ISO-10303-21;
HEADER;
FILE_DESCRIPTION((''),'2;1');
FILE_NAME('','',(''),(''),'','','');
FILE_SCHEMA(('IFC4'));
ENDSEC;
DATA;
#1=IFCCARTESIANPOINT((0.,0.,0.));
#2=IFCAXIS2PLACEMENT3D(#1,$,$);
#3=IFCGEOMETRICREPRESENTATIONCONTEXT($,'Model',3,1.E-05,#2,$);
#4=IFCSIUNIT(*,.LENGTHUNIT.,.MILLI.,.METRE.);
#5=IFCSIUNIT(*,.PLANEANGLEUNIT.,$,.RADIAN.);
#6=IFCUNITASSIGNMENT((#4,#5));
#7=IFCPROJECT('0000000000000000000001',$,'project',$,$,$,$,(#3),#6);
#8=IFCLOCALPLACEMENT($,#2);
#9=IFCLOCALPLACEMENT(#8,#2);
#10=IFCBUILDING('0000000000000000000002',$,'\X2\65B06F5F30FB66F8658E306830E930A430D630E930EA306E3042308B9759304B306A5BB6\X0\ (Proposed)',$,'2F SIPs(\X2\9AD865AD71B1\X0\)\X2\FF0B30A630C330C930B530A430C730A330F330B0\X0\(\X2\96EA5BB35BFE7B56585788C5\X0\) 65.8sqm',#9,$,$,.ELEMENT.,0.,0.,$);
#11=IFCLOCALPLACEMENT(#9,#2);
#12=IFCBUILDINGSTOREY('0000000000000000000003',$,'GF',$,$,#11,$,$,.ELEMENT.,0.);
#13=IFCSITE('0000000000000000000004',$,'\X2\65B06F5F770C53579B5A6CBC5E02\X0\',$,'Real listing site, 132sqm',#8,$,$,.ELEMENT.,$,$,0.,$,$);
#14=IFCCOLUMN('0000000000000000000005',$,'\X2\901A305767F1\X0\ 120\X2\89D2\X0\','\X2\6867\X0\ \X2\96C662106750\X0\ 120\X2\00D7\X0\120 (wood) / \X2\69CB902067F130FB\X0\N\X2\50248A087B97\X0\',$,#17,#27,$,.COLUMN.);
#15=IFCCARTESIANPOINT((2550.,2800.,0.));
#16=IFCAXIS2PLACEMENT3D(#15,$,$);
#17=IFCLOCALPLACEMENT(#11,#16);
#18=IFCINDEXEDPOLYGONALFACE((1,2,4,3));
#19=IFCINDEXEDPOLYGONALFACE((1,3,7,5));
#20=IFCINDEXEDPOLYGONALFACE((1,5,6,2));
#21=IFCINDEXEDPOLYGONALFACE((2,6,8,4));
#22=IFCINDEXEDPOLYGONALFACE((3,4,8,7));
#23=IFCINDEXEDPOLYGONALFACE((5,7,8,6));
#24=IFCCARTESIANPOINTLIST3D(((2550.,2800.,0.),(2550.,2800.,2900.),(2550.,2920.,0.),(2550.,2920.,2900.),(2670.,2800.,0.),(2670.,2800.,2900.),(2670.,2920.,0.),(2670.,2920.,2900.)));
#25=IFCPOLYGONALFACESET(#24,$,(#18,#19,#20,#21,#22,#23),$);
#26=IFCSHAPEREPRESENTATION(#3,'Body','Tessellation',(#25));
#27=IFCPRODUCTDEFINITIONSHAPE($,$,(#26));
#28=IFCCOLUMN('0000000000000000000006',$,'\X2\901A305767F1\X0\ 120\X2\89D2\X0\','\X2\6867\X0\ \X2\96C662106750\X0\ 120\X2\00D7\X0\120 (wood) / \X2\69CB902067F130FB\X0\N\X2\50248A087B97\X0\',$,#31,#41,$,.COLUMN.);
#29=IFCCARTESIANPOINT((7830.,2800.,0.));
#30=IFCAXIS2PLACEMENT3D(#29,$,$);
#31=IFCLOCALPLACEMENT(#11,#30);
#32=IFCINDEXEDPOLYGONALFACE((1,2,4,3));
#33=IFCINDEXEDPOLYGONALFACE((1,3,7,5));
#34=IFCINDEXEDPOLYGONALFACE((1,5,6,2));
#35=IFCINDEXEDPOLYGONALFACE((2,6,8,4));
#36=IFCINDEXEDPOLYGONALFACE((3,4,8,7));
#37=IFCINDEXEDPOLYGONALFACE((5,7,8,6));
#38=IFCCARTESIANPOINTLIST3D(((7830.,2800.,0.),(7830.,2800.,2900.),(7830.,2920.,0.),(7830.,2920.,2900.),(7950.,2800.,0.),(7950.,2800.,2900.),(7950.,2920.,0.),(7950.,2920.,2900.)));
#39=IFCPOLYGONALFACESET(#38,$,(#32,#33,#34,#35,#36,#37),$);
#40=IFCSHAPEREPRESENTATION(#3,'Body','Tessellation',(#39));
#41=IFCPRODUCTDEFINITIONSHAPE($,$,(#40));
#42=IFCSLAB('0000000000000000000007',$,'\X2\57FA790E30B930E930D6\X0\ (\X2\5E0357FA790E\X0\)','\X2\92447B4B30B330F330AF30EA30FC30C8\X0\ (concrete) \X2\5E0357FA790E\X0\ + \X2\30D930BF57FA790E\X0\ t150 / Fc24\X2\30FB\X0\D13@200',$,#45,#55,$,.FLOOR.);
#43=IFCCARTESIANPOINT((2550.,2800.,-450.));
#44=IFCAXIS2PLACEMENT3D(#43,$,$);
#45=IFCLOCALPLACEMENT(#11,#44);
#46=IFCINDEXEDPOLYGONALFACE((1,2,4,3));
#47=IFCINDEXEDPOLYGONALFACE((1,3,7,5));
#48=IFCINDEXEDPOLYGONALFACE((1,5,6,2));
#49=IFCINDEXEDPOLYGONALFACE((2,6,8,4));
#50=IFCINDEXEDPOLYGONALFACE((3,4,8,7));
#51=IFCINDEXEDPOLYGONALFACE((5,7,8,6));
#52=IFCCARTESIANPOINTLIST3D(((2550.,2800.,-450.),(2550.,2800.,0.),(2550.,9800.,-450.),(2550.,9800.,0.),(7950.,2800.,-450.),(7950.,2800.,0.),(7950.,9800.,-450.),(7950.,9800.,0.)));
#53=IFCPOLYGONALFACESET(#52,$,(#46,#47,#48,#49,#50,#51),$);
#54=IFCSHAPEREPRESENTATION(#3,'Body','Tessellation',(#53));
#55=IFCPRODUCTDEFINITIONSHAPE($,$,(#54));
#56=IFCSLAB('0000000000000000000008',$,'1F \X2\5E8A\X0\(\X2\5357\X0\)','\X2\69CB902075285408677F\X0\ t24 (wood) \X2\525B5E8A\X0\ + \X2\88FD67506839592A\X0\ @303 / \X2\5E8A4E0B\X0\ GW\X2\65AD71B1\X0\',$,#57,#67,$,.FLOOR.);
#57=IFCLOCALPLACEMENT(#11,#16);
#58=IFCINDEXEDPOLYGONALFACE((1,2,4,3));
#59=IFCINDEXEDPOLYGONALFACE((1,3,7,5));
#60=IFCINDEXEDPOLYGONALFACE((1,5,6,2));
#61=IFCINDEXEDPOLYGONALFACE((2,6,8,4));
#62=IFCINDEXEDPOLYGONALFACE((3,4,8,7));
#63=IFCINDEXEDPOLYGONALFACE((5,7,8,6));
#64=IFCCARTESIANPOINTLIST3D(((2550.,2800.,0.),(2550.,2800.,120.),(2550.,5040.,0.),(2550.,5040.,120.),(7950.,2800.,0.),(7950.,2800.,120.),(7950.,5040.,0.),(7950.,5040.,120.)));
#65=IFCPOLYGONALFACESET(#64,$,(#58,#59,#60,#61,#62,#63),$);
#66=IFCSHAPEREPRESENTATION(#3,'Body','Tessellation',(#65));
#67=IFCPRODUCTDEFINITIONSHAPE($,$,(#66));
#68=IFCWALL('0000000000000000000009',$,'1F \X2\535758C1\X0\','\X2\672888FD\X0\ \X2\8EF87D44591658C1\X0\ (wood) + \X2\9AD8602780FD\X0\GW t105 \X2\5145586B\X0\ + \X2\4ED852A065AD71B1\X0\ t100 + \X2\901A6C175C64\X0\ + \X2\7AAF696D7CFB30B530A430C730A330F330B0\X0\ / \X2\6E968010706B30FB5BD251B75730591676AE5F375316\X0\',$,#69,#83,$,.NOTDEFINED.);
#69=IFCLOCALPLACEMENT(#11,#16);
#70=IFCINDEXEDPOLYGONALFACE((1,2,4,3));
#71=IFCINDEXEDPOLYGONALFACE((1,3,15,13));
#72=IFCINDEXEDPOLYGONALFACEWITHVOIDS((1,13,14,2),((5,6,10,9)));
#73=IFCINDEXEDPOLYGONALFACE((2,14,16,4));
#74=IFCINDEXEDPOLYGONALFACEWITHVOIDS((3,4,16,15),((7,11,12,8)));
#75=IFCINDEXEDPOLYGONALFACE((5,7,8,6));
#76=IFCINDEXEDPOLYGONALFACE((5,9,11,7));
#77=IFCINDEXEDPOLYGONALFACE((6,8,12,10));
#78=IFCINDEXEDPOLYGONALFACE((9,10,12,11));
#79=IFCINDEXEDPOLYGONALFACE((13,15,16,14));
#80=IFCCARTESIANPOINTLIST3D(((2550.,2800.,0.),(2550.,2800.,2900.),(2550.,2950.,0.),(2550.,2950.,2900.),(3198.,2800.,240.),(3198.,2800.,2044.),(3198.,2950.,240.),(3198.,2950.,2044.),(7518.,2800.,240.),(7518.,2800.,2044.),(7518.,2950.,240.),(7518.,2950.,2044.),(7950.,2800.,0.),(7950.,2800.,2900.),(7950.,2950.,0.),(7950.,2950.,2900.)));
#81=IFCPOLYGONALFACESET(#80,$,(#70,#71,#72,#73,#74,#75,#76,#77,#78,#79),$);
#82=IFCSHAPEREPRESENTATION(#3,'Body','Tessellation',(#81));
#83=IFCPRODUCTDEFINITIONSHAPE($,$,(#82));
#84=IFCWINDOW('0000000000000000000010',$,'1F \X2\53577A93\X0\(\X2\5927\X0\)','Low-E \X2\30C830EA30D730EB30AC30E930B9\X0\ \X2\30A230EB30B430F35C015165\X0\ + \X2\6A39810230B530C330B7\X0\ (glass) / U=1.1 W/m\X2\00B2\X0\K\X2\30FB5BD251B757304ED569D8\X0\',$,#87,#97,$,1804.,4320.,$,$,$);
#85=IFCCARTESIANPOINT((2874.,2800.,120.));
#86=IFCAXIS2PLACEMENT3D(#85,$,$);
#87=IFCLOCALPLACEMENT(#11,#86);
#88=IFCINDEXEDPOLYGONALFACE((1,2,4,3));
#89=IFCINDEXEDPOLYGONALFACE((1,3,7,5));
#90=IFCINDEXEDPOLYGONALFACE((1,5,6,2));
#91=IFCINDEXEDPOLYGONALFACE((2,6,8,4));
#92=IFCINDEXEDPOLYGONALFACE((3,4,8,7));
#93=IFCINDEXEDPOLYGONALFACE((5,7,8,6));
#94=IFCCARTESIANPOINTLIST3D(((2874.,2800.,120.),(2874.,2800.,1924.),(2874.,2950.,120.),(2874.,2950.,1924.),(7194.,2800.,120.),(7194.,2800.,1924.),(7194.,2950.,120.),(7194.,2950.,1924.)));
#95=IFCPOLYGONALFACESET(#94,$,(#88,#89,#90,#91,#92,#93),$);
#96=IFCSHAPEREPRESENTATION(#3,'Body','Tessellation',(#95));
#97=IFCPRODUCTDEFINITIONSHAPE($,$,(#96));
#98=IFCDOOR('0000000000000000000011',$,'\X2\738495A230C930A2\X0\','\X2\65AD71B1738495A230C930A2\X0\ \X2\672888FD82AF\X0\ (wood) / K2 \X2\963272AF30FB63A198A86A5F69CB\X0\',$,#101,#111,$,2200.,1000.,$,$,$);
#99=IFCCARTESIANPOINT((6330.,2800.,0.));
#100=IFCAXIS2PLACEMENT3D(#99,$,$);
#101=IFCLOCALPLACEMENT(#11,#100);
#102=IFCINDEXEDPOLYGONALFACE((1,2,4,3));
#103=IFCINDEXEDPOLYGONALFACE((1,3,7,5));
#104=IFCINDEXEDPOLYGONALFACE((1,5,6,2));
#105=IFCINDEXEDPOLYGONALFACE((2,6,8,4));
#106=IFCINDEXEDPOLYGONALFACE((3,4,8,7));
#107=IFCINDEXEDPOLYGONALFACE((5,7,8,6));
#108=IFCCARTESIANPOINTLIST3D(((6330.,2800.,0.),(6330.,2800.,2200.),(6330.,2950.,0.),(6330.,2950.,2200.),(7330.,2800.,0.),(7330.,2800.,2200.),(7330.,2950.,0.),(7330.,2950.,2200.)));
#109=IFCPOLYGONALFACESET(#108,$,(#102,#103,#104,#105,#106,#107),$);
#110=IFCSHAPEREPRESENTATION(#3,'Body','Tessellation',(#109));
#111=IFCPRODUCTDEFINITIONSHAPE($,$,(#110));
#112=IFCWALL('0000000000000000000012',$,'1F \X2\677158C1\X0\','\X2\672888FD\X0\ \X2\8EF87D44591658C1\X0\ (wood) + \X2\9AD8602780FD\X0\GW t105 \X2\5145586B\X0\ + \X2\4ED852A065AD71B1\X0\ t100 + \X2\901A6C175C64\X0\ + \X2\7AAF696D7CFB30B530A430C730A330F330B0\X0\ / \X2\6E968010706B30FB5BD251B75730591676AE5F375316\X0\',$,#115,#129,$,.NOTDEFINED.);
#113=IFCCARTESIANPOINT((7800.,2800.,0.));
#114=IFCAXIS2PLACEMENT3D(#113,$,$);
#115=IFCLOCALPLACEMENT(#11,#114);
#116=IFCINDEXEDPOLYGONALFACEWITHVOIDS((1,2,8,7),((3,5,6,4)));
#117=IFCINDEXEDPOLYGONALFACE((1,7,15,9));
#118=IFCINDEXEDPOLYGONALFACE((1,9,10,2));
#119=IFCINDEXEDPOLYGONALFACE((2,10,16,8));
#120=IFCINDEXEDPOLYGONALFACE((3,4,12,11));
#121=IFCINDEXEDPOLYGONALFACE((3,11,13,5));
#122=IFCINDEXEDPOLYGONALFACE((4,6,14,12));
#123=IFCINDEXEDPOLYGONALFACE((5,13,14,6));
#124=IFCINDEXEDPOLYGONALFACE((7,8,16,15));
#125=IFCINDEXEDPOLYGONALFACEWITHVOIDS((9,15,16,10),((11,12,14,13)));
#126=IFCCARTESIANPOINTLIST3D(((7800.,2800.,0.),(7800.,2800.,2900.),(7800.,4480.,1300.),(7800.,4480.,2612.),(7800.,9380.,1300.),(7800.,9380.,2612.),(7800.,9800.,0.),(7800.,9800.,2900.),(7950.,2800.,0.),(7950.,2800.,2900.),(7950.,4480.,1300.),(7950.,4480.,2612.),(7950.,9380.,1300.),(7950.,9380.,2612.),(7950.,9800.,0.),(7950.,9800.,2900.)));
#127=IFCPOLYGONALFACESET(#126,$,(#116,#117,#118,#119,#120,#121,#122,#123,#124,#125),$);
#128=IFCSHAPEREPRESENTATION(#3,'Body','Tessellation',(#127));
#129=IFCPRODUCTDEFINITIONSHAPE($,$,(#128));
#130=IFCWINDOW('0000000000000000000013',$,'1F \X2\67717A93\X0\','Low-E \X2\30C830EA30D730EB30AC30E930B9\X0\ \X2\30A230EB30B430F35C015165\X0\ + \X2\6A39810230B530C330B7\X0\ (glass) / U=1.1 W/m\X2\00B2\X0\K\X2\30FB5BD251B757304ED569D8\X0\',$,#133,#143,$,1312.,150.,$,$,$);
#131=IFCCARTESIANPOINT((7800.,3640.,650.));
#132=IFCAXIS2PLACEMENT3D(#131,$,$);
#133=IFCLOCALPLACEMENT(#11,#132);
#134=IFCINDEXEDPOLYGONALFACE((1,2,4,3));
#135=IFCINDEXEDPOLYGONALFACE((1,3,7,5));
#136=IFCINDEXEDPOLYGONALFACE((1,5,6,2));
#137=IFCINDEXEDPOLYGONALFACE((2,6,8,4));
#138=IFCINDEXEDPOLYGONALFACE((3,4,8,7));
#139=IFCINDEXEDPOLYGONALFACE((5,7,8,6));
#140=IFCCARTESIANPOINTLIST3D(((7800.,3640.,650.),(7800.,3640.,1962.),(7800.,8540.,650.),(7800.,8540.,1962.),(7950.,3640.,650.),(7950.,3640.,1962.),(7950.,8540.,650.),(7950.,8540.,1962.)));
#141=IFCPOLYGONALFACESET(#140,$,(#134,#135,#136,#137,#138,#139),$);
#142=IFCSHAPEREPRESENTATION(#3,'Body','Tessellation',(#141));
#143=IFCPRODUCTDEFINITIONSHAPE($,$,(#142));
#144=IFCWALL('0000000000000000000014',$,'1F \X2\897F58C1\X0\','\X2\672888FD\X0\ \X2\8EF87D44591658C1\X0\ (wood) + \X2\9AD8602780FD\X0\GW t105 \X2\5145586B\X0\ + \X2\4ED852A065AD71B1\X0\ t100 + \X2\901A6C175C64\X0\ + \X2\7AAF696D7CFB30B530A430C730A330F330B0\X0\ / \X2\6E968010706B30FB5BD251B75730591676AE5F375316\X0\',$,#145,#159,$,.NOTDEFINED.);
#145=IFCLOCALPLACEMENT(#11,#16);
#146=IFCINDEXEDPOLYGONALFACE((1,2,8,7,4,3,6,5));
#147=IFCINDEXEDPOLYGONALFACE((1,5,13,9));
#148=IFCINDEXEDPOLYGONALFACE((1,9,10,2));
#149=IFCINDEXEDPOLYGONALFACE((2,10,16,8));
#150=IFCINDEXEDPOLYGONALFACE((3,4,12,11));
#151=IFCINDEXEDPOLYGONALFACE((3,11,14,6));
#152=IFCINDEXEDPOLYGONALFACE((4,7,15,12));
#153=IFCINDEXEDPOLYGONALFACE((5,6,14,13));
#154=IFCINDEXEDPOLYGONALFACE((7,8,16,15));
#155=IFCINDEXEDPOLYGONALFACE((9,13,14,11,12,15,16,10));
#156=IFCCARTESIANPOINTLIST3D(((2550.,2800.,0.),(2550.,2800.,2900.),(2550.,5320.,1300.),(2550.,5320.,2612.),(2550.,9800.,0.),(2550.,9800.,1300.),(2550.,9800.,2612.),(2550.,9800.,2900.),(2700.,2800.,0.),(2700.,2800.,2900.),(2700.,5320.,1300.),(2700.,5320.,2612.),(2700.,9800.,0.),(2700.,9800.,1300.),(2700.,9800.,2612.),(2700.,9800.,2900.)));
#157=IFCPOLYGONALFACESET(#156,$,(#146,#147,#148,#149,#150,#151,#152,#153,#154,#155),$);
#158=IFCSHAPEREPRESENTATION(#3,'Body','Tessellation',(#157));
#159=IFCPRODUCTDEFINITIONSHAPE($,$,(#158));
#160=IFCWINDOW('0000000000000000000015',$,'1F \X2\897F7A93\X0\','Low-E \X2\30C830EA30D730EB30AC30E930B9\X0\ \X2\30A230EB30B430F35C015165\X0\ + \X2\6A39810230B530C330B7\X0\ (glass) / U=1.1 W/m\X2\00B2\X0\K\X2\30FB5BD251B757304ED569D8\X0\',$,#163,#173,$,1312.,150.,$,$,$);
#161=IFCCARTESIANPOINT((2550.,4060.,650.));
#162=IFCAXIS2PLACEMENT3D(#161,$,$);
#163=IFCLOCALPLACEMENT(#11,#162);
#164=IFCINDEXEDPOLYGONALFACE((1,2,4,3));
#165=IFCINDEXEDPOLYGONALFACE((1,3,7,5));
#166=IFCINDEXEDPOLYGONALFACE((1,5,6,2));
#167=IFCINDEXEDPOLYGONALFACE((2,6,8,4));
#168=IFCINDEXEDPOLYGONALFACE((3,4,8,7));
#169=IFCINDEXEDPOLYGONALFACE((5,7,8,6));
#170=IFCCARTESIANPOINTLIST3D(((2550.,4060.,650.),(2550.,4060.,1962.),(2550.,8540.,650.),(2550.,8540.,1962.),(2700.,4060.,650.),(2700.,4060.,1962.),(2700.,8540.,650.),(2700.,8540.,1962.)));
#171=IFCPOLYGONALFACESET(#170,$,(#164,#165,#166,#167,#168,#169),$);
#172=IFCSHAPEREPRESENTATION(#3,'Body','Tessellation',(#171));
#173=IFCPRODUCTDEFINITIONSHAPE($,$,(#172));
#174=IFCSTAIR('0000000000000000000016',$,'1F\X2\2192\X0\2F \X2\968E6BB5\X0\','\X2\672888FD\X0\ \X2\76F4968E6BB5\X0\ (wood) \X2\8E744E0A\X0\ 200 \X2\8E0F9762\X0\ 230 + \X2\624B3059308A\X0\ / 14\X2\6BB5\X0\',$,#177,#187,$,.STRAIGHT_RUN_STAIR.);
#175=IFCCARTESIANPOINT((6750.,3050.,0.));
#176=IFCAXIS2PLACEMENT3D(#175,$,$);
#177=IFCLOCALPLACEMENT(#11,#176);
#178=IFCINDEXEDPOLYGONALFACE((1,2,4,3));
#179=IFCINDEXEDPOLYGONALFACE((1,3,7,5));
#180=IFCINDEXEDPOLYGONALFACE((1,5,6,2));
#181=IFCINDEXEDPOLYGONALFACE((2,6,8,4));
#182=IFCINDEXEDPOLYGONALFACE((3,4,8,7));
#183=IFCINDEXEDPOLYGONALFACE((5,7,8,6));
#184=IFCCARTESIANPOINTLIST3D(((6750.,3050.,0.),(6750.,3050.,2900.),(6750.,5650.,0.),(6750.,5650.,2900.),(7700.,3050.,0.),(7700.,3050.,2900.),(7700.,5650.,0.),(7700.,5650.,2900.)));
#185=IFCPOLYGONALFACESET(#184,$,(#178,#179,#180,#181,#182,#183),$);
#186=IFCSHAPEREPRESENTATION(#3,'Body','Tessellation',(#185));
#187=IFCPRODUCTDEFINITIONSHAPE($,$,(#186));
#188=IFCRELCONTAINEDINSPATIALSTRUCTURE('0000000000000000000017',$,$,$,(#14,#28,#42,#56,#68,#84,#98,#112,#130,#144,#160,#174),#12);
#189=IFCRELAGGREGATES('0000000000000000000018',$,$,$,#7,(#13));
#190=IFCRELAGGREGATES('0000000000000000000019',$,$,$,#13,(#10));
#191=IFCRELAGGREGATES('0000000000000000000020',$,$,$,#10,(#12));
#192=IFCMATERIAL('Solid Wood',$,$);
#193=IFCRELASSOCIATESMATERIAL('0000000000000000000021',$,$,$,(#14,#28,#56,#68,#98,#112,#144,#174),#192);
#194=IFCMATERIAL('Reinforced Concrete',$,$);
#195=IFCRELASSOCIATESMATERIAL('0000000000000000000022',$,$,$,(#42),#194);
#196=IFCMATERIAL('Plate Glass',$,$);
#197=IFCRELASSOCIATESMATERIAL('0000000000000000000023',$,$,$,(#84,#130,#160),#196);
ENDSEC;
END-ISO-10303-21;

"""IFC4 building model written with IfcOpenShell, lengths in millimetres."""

from ifc_helpers import new_model, si_unit, frame, frame_2d, origin, place, context, project, spatial, rectangle, extrude, material, element, fill, save


model = new_model("IFC4")

# Units and contexts
model_context = context("Model", 3, precision=1e-05, world=origin())
ifc_project = project(units=[si_unit("LENGTHUNIT", "METRE", prefix="MILLI"), si_unit("PLANEANGLEUNIT", "RADIAN")], contexts=[model_context])

# Site, building, storey
site_placement = place(None, origin())
site = spatial("IfcSite", under=ifc_project, at=site_placement, Name="新潟県南魚沼市", ObjectType="Real listing site, 132sqm", CompositionType="ELEMENT", RefElevation=0.0)
building_placement = place(site_placement, origin())
building = spatial("IfcBuilding", under=site, at=building_placement, Name="新潟・書斎とライブラリのある静かな家 (Proposed)", ObjectType="2F SIPs(高断熱)＋ウッドサイディング(雪害対策塗装) 65.8sqm", CompositionType="ELEMENT", ElevationOfRefHeight=0.0, ElevationOfTerrain=0.0)
storey_placement = place(building_placement, origin())
storey = spatial("IfcBuildingStorey", under=building, at=storey_placement, Name="GF", CompositionType="ELEMENT", Elevation=0.0)

# Columns
ifc_material_1 = material(Name="Solid Wood")
column_1_placement = place(storey_placement, frame((2550.0, 2800.0, 0.0)))
element("IfcColumn", 1, at=column_1_placement, inside=storey, material=ifc_material_1, Name="通し柱 120角", Description="桧 集成材 120×120 (wood) / 構造柱・N値計算", PredefinedType="COLUMN", context=model_context, shape_type="SweptSolid", body=[
    extrude(rectangle(XDim=120.0, YDim=120.0, at=frame_2d((60.0, 60.0))), frame((2550.0, 2800.0, 0.0)), (0.0, 0.0, 1.0), 2900.0),
])
column_2_placement = place(storey_placement, frame((7830.0, 2800.0, 0.0)))
element("IfcColumn", 2, at=column_2_placement, inside=storey, material=ifc_material_1, Name="通し柱 120角", Description="桧 集成材 120×120 (wood) / 構造柱・N値計算", PredefinedType="COLUMN", context=model_context, shape_type="SweptSolid", body=[
    extrude(rectangle(XDim=120.0, YDim=120.0, at=frame_2d((60.0, 60.0))), frame((7830.0, 2800.0, 0.0)), (0.0, 0.0, 1.0), 2900.0),
])

# Slabs
ifc_material_2 = material(Name="Reinforced Concrete")
slab_1_placement = place(storey_placement, frame((2550.0, 2800.0, -450.0)))
element("IfcSlab", 3, at=slab_1_placement, inside=storey, material=ifc_material_2, Name="基礎スラブ (布基礎)", Description="鉄筋コンクリート (concrete) 布基礎 + ベタ基礎 t150 / Fc24・D13@200", PredefinedType="FLOOR", context=model_context, shape_type="SweptSolid", body=[
    extrude(rectangle(XDim=5400.0, YDim=7000.0, at=frame_2d((2700.0, 3500.0))), frame((2550.0, 2800.0, -450.0)), (0.0, 0.0, 1.0), 450.0),
])
slab_2_placement = place(storey_placement, frame((2550.0, 2800.0, 0.0)))
element("IfcSlab", 4, at=slab_2_placement, inside=storey, material=ifc_material_1, Name="1F 床(南)", Description="構造用合板 t24 (wood) 剛床 + 製材根太 @303 / 床下 GW断熱", PredefinedType="FLOOR", context=model_context, shape_type="SweptSolid", body=[
    extrude(rectangle(XDim=5400.0, YDim=2240.0, at=frame_2d((2700.0, 1120.0))), frame((2550.0, 2800.0, 0.0)), (0.0, 0.0, 1.0), 120.0),
])

# Wall, openings, window, door
wall_1_placement = place(storey_placement, frame((2550.0, 2800.0, 0.0)))
wall_1 = element("IfcWall", 5, at=wall_1_placement, inside=storey, material=ifc_material_1, Name="1F 南壁", Description="木製 軸組外壁 (wood) + 高性能GW t105 充填 + 付加断熱 t100 + 通気層 + 窯業系サイディング / 準耐火・寒冷地外皮強化", PredefinedType="NOTDEFINED", context=model_context, shape_type="SweptSolid", body=[
    extrude(rectangle(XDim=5400.0, YDim=150.0, at=frame_2d((2700.0, 75.0))), frame((2550.0, 2800.0, 0.0)), (0.0, 0.0, 1.0), 2900.0),
])
opening_1_placement = place(storey_placement, frame((2874.0, 2800.0, 120.0)))
opening_1 = element("IfcOpeningElement", 6, at=opening_1_placement, cuts=wall_1, PredefinedType="NOTDEFINED", context=model_context, shape_type="SweptSolid", body=[
    extrude(rectangle(XDim=4320.0, YDim=150.0, at=frame_2d((2160.0, 75.0))), frame((2874.0, 2800.0, 120.0)), (0.0, 0.0, 1.0), 1804.0),
])
opening_2_placement = place(storey_placement, frame((6330.0, 2800.0, 0.0)))
opening_2 = element("IfcOpeningElement", 7, at=opening_2_placement, cuts=wall_1, PredefinedType="NOTDEFINED", context=model_context, shape_type="SweptSolid", body=[
    extrude(rectangle(XDim=1000.0, YDim=150.0, at=frame_2d((500.0, 75.0))), frame((6330.0, 2800.0, 0.0)), (0.0, 0.0, 1.0), 2200.0),
])
ifc_material_3 = material(Name="Plate Glass")
window_1_placement = place(storey_placement, frame((2874.0, 2800.0, 120.0)))
window_1 = element("IfcWindow", 8, at=window_1_placement, inside=storey, material=ifc_material_3, Name="1F 南窓(大)", Description="Low-E トリプルガラス アルゴン封入 + 樹脂サッシ (glass) / U=1.1 W/m²K・寒冷地仕様", OverallHeight=1804.0, OverallWidth=4320.0, context=model_context, shape_type="SweptSolid", body=[
    extrude(rectangle(XDim=4320.0, YDim=150.0, at=frame_2d((2160.0, 75.0))), frame((2874.0, 2800.0, 120.0)), (0.0, 0.0, 1.0), 1804.0),
])
fill(opening_1, window_1)
door_placement = place(storey_placement, frame((6330.0, 2800.0, 0.0)))
door = element("IfcDoor", 9, at=door_placement, inside=storey, material=ifc_material_1, Name="玄関ドア", Description="断熱玄関ドア 木製芯 (wood) / K2 防犯・採風機構", OverallHeight=2200.0, OverallWidth=1000.0, context=model_context, shape_type="SweptSolid", body=[
    extrude(rectangle(XDim=1000.0, YDim=150.0, at=frame_2d((500.0, 75.0))), frame((6330.0, 2800.0, 0.0)), (0.0, 0.0, 1.0), 2200.0),
])
fill(opening_2, door)

# Walls, openings, windows
wall_2_placement = place(storey_placement, frame((7800.0, 2800.0, 0.0)))
wall_2 = element("IfcWall", 10, at=wall_2_placement, inside=storey, material=ifc_material_1, Name="1F 東壁", Description="木製 軸組外壁 (wood) + 高性能GW t105 充填 + 付加断熱 t100 + 通気層 + 窯業系サイディング / 準耐火・寒冷地外皮強化", PredefinedType="NOTDEFINED", context=model_context, shape_type="SweptSolid", body=[
    extrude(rectangle(XDim=150.0, YDim=7000.0, at=frame_2d((75.0, 3500.0))), frame((7800.0, 2800.0, 0.0)), (0.0, 0.0, 1.0), 2900.0),
])
opening_3_placement = place(storey_placement, frame((7800.0, 3640.0, 650.0)))
opening_3 = element("IfcOpeningElement", 11, at=opening_3_placement, cuts=wall_2, PredefinedType="NOTDEFINED", context=model_context, shape_type="SweptSolid", body=[
    extrude(rectangle(XDim=150.0, YDim=4900.0, at=frame_2d((75.0, 2450.0))), frame((7800.0, 3640.0, 650.0)), (0.0, 0.0, 1.0), 1312.0),
])
window_2_placement = place(storey_placement, frame((7800.0, 3640.0, 650.0)))
window_2 = element("IfcWindow", 12, at=window_2_placement, inside=storey, material=ifc_material_3, Name="1F 東窓", Description="Low-E トリプルガラス アルゴン封入 + 樹脂サッシ (glass) / U=1.1 W/m²K・寒冷地仕様", OverallHeight=1312.0, OverallWidth=150.0, context=model_context, shape_type="SweptSolid", body=[
    extrude(rectangle(XDim=150.0, YDim=4900.0, at=frame_2d((75.0, 2450.0))), frame((7800.0, 3640.0, 650.0)), (0.0, 0.0, 1.0), 1312.0),
])
fill(opening_3, window_2)
wall_3_placement = place(storey_placement, frame((2550.0, 2800.0, 0.0)))
wall_3 = element("IfcWall", 13, at=wall_3_placement, inside=storey, material=ifc_material_1, Name="1F 西壁", Description="木製 軸組外壁 (wood) + 高性能GW t105 充填 + 付加断熱 t100 + 通気層 + 窯業系サイディング / 準耐火・寒冷地外皮強化", PredefinedType="NOTDEFINED", context=model_context, shape_type="SweptSolid", body=[
    extrude(rectangle(XDim=150.0, YDim=7000.0, at=frame_2d((75.0, 3500.0))), frame((2550.0, 2800.0, 0.0)), (0.0, 0.0, 1.0), 2900.0),
])
opening_4_placement = place(storey_placement, frame((2550.0, 4060.0, 650.0)))
opening_4 = element("IfcOpeningElement", 14, at=opening_4_placement, cuts=wall_3, PredefinedType="NOTDEFINED", context=model_context, shape_type="SweptSolid", body=[
    extrude(rectangle(XDim=150.0, YDim=4480.0, at=frame_2d((75.0, 2240.0))), frame((2550.0, 4060.0, 650.0)), (0.0, 0.0, 1.0), 1312.0),
])
window_3_placement = place(storey_placement, frame((2550.0, 4060.0, 650.0)))
window_3 = element("IfcWindow", 15, at=window_3_placement, inside=storey, material=ifc_material_3, Name="1F 西窓", Description="Low-E トリプルガラス アルゴン封入 + 樹脂サッシ (glass) / U=1.1 W/m²K・寒冷地仕様", OverallHeight=1312.0, OverallWidth=150.0, context=model_context, shape_type="SweptSolid", body=[
    extrude(rectangle(XDim=150.0, YDim=4480.0, at=frame_2d((75.0, 2240.0))), frame((2550.0, 4060.0, 650.0)), (0.0, 0.0, 1.0), 1312.0),
])
fill(opening_4, window_3)

# Stair
stair_placement = place(storey_placement, frame((6750.0, 3050.0, 0.0)))
element("IfcStair", 16, at=stair_placement, inside=storey, material=ifc_material_1, Name="1F→2F 階段", Description="木製 直階段 (wood) 蹴上 200 踏面 230 + 手すり / 14段", PredefinedType="STRAIGHT_RUN_STAIR", context=model_context, shape_type="SweptSolid", body=[
    extrude(rectangle(XDim=950.0, YDim=2600.0, at=frame_2d((475.0, 1300.0))), frame((6750.0, 3050.0, 0.0)), (0.0, 0.0, 1.0), 2900.0),
])

save(model, "model.ifc")
